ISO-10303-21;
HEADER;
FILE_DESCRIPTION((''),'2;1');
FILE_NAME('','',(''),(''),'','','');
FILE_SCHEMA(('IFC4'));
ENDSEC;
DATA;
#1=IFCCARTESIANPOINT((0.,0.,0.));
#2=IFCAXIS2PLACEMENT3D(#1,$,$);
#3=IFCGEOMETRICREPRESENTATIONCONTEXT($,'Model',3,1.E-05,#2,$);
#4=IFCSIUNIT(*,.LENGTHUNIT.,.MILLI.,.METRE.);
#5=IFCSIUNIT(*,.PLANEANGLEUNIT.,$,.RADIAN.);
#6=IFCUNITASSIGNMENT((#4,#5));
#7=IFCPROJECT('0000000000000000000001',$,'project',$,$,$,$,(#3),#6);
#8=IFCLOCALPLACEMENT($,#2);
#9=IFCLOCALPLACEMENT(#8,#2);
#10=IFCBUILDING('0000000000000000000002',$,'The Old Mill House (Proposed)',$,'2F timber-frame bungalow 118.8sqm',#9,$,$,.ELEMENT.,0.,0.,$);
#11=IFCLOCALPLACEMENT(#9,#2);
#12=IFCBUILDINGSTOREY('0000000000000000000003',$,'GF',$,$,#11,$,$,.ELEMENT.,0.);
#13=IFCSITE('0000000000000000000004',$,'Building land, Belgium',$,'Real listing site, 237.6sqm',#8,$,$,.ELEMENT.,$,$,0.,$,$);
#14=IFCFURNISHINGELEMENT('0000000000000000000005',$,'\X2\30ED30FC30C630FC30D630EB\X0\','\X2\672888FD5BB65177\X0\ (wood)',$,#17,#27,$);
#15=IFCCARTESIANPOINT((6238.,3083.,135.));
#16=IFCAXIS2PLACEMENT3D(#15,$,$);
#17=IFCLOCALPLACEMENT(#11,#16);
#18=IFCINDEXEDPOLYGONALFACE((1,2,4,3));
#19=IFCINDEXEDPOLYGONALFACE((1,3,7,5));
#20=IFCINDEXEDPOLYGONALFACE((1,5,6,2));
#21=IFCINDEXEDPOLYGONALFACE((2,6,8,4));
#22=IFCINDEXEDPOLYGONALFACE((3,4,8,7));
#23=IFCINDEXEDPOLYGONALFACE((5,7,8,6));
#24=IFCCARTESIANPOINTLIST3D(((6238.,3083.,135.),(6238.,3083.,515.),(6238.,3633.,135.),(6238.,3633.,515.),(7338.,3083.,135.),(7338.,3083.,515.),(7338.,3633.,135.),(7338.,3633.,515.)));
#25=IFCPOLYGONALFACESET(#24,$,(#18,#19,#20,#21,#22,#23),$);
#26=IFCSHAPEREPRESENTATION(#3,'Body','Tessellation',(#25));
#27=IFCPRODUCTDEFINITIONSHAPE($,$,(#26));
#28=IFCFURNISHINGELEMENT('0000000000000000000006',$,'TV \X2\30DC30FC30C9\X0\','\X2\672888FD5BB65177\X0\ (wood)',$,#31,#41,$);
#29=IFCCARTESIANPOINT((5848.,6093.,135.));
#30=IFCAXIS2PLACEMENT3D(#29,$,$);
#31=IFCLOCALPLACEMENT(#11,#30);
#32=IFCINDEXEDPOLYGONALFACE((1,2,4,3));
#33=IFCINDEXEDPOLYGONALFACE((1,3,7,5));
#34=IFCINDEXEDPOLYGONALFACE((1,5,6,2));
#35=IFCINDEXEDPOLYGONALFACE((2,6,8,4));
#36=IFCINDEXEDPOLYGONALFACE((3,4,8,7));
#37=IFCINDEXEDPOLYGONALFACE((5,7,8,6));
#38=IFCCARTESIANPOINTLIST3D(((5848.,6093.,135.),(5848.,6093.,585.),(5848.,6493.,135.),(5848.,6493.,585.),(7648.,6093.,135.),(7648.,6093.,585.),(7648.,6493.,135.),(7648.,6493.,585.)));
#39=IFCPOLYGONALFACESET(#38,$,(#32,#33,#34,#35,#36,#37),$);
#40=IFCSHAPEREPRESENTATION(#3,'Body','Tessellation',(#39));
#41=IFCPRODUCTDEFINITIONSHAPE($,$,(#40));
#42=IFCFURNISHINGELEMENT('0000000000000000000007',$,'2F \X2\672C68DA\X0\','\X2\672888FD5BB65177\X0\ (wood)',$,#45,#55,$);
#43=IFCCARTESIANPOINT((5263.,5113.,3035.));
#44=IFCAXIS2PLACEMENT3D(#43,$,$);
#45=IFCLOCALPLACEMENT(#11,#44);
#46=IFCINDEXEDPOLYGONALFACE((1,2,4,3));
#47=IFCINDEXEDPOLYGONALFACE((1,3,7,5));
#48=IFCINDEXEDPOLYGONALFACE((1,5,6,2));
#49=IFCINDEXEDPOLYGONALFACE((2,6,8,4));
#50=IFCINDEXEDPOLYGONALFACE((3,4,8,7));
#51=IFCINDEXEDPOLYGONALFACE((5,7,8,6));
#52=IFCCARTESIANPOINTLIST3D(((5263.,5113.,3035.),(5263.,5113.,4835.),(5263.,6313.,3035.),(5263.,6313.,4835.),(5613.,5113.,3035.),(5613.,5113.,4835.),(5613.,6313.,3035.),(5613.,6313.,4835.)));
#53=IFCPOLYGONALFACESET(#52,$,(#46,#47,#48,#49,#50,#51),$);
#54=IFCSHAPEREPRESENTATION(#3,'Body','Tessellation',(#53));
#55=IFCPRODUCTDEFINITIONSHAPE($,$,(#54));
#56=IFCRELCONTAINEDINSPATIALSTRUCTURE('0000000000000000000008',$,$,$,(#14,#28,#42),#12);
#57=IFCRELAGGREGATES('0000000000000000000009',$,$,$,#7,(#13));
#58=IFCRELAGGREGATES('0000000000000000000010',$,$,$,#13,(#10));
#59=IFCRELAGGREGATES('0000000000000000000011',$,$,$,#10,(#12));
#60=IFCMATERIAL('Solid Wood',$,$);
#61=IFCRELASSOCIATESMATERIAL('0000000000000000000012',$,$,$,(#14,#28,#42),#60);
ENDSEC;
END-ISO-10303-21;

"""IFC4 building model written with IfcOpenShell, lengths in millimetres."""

from ifc_helpers import new_model, si_unit, frame, frame_2d, origin, place, context, project, spatial, rectangle, extrude, material, element, save


model = new_model("IFC4")

# Units and contexts
model_context = context("Model", 3, precision=1e-05, world=origin())
ifc_project = project(units=[si_unit("LENGTHUNIT", "METRE", prefix="MILLI"), si_unit("PLANEANGLEUNIT", "RADIAN")], contexts=[model_context])

# Site, building, storey
site_placement = place(None, origin())
site = spatial("IfcSite", under=ifc_project, at=site_placement, Name="Building land, Belgium", ObjectType="Real listing site, 237.6sqm", CompositionType="ELEMENT", RefElevation=0.0)
building_placement = place(site_placement, origin())
building = spatial("IfcBuilding", under=site, at=building_placement, Name="The Old Mill House (Proposed)", ObjectType="2F timber-frame bungalow 118.8sqm", CompositionType="ELEMENT", ElevationOfRefHeight=0.0, ElevationOfTerrain=0.0)
storey_placement = place(building_placement, origin())
storey = spatial("IfcBuildingStorey", under=building, at=storey_placement, Name="GF", CompositionType="ELEMENT", Elevation=0.0)

# Shared definitions
ifc_material_1 = material(Name="Solid Wood")

# Furnishing elements
furnishing_1_placement = place(storey_placement, frame((6238.0, 3083.0, 135.0)))
element("IfcFurnishingElement", 1, at=furnishing_1_placement, inside=storey, material=ifc_material_1, Name="ローテーブル", Description="木製家具 (wood)", context=model_context, shape_type="SweptSolid", body=[
    extrude(rectangle(XDim=1100.0, YDim=550.0, at=frame_2d((550.0, 275.0))), frame((6238.0, 3083.0, 135.0)), (0.0, 0.0, 1.0), 380.0),
])
furnishing_2_placement = place(storey_placement, frame((5848.0, 6093.0, 135.0)))
element("IfcFurnishingElement", 2, at=furnishing_2_placement, inside=storey, material=ifc_material_1, Name="TV ボード", Description="木製家具 (wood)", context=model_context, shape_type="SweptSolid", body=[
    extrude(rectangle(XDim=1800.0, YDim=400.0, at=frame_2d((900.0, 200.0))), frame((5848.0, 6093.0, 135.0)), (0.0, 0.0, 1.0), 450.0),
])
furnishing_3_placement = place(storey_placement, frame((5263.0, 5113.0, 3035.0)))
element("IfcFurnishingElement", 3, at=furnishing_3_placement, inside=storey, material=ifc_material_1, Name="2F 本棚", Description="木製家具 (wood)", context=model_context, shape_type="SweptSolid", body=[
    extrude(rectangle(XDim=350.0, YDim=1200.0, at=frame_2d((175.0, 600.0))), frame((5263.0, 5113.0, 3035.0)), (0.0, 0.0, 1.0), 1800.0),
])

save(model, "model.ifc")
